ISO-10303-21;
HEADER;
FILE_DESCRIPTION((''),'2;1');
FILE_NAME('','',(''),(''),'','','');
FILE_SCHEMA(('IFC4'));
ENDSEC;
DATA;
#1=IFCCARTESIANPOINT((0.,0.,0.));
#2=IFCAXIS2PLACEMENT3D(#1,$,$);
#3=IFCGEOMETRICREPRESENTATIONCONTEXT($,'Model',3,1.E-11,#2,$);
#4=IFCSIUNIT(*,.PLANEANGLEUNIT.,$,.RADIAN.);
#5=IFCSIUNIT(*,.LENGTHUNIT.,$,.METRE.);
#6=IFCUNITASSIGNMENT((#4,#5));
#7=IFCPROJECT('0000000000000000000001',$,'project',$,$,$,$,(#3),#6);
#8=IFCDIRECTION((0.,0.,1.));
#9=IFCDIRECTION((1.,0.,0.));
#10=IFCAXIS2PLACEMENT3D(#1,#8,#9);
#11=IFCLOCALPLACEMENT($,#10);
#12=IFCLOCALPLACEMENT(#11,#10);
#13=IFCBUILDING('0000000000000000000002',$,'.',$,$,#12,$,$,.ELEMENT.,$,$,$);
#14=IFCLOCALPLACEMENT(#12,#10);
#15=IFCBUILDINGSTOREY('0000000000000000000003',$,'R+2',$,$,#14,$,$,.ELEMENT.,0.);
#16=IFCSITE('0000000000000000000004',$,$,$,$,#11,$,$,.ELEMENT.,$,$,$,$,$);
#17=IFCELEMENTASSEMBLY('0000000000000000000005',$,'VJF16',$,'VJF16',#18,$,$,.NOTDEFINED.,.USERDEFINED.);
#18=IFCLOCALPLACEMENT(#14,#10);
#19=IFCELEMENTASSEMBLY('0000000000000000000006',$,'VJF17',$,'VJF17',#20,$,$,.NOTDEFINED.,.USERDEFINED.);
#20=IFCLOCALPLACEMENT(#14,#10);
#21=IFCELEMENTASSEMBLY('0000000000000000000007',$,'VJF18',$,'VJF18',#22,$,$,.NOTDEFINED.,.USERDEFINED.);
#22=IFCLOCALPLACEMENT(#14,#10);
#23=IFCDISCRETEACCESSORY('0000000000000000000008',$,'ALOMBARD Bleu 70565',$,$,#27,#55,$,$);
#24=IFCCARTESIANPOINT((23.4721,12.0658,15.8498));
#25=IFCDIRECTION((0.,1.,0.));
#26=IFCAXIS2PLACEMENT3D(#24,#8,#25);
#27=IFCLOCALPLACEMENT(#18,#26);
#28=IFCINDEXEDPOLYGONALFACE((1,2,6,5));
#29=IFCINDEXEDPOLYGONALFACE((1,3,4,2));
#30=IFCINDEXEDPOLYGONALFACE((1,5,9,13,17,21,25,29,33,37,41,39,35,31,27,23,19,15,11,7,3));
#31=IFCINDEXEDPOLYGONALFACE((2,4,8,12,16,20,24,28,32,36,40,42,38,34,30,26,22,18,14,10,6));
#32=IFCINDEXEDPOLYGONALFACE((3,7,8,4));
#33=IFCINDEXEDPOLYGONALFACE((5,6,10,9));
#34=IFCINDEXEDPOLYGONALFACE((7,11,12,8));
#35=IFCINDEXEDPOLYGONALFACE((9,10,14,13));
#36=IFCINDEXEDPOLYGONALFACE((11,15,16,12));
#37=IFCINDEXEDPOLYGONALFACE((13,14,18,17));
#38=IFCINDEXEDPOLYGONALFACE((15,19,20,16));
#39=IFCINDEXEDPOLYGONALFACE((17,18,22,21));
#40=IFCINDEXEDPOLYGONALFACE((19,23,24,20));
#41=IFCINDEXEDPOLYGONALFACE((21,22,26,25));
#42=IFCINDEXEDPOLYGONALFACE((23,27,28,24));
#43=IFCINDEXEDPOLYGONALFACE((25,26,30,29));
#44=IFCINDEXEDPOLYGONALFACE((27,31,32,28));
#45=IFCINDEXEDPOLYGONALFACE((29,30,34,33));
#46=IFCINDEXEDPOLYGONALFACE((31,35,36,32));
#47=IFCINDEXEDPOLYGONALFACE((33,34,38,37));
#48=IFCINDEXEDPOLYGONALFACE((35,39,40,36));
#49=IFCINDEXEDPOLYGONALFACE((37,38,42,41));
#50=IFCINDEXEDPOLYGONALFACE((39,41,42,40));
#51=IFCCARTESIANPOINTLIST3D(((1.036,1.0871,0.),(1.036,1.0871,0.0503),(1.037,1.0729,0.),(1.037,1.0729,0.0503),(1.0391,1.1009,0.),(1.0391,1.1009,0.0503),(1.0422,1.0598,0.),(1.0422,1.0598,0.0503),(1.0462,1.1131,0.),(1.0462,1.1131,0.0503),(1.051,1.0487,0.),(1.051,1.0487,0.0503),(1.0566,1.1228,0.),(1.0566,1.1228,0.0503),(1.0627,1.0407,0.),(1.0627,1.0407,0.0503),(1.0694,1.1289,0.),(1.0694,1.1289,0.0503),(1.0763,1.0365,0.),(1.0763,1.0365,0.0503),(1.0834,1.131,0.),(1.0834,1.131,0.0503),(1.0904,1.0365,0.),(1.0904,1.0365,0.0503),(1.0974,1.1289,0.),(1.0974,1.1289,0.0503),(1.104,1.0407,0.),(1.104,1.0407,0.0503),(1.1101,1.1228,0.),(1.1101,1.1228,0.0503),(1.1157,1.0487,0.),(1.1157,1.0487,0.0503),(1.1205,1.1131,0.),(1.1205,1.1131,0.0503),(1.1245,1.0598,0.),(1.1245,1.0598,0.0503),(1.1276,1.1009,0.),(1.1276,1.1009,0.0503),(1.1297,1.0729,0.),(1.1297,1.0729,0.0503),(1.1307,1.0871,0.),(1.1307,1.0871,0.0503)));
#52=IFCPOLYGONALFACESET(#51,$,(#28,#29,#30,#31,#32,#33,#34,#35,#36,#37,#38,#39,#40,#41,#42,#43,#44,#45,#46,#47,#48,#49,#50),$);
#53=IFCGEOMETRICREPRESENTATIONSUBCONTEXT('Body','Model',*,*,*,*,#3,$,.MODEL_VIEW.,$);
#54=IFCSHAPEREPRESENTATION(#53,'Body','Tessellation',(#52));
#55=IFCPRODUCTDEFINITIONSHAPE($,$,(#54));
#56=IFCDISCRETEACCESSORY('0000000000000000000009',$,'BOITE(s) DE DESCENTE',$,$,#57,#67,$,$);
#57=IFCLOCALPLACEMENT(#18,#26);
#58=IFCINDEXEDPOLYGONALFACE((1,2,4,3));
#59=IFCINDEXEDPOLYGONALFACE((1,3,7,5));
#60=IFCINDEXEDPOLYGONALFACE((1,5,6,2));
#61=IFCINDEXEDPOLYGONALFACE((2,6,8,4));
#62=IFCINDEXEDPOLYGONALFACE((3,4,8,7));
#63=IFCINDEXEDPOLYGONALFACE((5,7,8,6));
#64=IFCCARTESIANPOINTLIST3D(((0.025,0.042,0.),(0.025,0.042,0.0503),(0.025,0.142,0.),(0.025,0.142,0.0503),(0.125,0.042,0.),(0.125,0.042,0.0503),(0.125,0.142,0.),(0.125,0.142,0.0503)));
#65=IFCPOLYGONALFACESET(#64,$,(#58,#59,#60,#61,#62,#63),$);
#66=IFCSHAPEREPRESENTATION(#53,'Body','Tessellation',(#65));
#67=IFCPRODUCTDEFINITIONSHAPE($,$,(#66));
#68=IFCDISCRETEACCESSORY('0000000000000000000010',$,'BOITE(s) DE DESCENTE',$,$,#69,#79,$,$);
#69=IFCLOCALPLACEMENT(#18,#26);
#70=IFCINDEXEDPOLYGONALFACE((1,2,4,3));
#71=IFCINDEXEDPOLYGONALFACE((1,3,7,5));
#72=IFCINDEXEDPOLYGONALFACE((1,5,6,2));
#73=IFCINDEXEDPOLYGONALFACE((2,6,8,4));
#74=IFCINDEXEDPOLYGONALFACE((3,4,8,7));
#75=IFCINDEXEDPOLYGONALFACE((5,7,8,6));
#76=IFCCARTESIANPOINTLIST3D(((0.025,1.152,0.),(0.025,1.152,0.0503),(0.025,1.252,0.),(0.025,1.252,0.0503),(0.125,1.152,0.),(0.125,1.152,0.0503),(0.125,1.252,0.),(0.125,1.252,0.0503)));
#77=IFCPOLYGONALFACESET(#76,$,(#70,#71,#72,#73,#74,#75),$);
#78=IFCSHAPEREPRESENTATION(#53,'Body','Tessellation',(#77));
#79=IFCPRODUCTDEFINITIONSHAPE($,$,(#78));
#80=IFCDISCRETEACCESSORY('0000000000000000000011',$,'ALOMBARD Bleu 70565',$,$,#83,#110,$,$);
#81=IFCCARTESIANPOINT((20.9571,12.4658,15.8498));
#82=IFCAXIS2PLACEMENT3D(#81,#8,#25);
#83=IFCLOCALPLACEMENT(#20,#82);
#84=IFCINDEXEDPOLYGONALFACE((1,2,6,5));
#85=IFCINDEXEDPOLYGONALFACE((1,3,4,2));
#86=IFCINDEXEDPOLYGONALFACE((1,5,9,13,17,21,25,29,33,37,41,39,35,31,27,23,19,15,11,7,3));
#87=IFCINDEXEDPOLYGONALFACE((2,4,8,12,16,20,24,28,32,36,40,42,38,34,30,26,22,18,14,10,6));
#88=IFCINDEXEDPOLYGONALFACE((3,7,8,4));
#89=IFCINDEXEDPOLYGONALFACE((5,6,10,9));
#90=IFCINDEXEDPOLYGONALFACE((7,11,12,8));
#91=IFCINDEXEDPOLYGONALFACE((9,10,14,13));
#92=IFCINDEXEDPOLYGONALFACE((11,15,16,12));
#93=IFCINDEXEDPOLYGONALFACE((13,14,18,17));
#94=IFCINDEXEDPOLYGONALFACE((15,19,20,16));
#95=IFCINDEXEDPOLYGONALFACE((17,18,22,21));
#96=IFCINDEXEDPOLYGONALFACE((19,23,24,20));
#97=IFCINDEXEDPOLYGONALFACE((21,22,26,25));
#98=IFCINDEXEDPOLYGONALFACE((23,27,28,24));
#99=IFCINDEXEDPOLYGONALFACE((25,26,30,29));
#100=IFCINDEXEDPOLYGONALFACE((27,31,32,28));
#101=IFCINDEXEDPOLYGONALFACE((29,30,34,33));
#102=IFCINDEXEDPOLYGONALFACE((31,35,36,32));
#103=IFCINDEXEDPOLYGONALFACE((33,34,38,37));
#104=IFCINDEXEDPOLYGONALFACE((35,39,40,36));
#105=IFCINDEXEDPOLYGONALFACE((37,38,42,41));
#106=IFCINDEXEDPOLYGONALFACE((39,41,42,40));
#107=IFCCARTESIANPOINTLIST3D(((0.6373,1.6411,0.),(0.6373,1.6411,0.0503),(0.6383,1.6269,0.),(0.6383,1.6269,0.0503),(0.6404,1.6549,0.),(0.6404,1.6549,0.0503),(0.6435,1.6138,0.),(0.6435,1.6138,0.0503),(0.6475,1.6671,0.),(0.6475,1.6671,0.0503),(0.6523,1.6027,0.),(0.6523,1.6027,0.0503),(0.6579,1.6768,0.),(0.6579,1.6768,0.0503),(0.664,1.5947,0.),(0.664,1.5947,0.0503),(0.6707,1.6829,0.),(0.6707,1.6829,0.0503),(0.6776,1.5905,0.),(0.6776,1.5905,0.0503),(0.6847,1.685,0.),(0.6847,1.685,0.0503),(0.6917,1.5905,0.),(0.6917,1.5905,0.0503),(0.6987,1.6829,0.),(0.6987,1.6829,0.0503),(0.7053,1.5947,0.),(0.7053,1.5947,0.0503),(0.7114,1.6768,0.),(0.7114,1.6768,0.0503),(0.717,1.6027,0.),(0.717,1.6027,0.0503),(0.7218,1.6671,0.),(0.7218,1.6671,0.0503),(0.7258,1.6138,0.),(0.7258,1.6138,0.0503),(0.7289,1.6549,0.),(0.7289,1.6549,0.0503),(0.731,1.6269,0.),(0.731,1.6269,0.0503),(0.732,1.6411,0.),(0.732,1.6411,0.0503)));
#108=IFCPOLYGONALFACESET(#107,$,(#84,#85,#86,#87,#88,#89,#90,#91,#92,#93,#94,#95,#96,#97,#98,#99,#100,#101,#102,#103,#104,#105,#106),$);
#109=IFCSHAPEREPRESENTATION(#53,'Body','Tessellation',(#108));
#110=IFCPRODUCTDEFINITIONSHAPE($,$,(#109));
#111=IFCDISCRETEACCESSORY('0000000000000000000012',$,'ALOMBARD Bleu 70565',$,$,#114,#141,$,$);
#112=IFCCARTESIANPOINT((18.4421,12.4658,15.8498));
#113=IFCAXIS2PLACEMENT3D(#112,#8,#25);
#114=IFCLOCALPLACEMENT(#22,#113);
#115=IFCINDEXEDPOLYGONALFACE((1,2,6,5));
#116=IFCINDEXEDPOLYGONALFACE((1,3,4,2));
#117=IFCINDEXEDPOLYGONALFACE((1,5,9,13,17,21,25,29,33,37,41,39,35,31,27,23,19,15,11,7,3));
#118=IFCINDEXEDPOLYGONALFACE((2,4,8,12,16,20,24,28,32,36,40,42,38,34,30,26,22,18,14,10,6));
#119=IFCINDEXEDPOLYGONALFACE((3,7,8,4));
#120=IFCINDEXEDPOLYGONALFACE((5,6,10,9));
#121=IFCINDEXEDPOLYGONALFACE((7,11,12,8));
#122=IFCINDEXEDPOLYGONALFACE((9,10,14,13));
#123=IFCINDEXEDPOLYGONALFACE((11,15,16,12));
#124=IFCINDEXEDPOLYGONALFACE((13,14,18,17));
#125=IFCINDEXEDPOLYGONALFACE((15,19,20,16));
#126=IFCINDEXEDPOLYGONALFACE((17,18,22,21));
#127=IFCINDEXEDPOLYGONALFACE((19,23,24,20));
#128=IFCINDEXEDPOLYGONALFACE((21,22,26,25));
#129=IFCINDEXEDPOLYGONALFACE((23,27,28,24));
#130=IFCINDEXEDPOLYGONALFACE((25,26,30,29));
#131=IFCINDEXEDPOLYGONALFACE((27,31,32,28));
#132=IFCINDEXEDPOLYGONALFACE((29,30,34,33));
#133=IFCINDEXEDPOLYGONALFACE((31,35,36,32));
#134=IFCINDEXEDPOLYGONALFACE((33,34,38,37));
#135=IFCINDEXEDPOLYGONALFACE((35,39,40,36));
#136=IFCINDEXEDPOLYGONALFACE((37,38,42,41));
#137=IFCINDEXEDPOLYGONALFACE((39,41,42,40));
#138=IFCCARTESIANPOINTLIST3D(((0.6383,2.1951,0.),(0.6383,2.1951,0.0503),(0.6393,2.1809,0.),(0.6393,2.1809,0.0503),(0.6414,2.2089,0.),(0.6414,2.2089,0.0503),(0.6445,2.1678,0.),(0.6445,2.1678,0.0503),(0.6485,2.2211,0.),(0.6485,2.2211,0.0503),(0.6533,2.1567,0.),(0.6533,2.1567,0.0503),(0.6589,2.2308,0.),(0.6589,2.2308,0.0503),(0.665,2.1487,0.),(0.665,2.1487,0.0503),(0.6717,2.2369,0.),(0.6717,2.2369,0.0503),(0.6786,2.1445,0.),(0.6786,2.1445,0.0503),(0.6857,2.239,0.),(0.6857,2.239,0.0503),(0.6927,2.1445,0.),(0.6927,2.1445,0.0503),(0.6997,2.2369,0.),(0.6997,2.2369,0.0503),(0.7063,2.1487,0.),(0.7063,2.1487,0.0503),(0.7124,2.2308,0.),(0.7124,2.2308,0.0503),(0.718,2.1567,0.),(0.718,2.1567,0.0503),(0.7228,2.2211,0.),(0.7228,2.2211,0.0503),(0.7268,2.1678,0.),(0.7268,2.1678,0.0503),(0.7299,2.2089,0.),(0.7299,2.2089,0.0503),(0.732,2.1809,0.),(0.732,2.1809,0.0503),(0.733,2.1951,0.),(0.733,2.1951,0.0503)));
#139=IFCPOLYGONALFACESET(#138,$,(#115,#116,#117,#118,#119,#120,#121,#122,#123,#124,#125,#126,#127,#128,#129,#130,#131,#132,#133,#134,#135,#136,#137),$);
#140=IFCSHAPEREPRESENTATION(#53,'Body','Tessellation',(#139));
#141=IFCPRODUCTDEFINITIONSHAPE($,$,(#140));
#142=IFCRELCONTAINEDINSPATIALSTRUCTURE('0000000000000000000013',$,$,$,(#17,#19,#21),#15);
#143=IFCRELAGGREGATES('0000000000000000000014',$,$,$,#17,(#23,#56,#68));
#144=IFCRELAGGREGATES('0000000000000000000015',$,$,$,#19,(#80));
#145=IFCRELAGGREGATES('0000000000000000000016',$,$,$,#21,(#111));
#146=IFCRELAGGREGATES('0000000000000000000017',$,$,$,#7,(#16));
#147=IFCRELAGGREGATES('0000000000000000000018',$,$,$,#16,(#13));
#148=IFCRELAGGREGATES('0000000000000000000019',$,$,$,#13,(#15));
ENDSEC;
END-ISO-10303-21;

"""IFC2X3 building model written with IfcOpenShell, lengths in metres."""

from ifc_helpers import new_model, si_unit, frame, frame_2d, origin, origin_with_axes, place, context, subcontext, project, spatial, polyline, circle, outline, extrude, element, aggregate, save


model = new_model("IFC2X3")

# Units and contexts
model_context = context("Model", 3, precision=1e-11, world=origin())
body_context = subcontext(model_context, "Body", "Model", "MODEL_VIEW")
ifc_project = project(units=[si_unit("PLANEANGLEUNIT", "RADIAN"), si_unit("LENGTHUNIT", "METRE")], contexts=[model_context])

# Site, building, storey
site_placement = place(None, origin_with_axes())
site = spatial("IfcSite", under=ifc_project, at=site_placement, CompositionType="ELEMENT")
building_placement = place(site_placement, origin_with_axes())
building = spatial("IfcBuilding", under=site, at=building_placement, Name=".", CompositionType="ELEMENT")
storey_placement = place(building_placement, origin_with_axes())
storey = spatial("IfcBuildingStorey", under=building, at=storey_placement, Name="R+2", CompositionType="ELEMENT", Elevation=0.0)

# Element assembly
assembly_1_placement = place(storey_placement, origin_with_axes())
assembly_1 = element("IfcElementAssembly", 1, at=assembly_1_placement, inside=storey, Name="VJF16", ObjectType="VJF16", AssemblyPlace="NOTDEFINED", PredefinedType="USERDEFINED")

# Element assemblies
assembly_2_placement = place(storey_placement, origin_with_axes())
assembly_2 = element("IfcElementAssembly", 2, at=assembly_2_placement, inside=storey, Name="VJF17", ObjectType="VJF17", AssemblyPlace="NOTDEFINED", PredefinedType="USERDEFINED")
assembly_3_placement = place(storey_placement, origin_with_axes())
assembly_3 = element("IfcElementAssembly", 3, at=assembly_3_placement, inside=storey, Name="VJF18", ObjectType="VJF18", AssemblyPlace="NOTDEFINED", PredefinedType="USERDEFINED")

# Discrete accessories
discrete_accessory_1_placement = place(assembly_1_placement, frame((23.4721, 12.0658, 15.8498), z_axis=(0.0, 0.0, 1.0), x_axis=(0.0, 1.0, 0.0)))
discrete_accessory_1 = element("IfcDiscreteAccessory", 4, at=discrete_accessory_1_placement, Name="ALOMBARD Bleu 70565", context=body_context, shape_type="SweptSolid", body=[
    extrude(circle(Radius=0.0475, at=frame_2d((1.0835, -1.0834), x_axis=(1.0, 0.0))), frame((0.0, 0.0, 0.0), z_axis=(0.0, 0.0, 1.0), x_axis=(0.0, 1.0, 0.0)), (0.0, 0.0, 1.0), 0.0503),
])
discrete_accessory_2_placement = place(assembly_1_placement, frame((23.4721, 12.0658, 15.8498), z_axis=(0.0, 0.0, 1.0), x_axis=(0.0, 1.0, 0.0)))
discrete_accessory_2 = element("IfcDiscreteAccessory", 5, at=discrete_accessory_2_placement, Name="BOITE(s) DE DESCENTE", context=body_context, shape_type="SweptSolid", body=[
    extrude(outline(polyline([(0.042, -0.025), (0.042, -0.125), (0.142, -0.125), (0.142, -0.025), (0.042, -0.025)])), frame((0.0, 0.0, 0.0), z_axis=(0.0, 0.0, 1.0), x_axis=(0.0, 1.0, 0.0)), (0.0, 0.0, 1.0), 0.0503),
])
discrete_accessory_3_placement = place(assembly_1_placement, frame((23.4721, 12.0658, 15.8498), z_axis=(0.0, 0.0, 1.0), x_axis=(0.0, 1.0, 0.0)))
discrete_accessory_3 = element("IfcDiscreteAccessory", 6, at=discrete_accessory_3_placement, Name="BOITE(s) DE DESCENTE", context=body_context, shape_type="SweptSolid", body=[
    extrude(outline(polyline([(1.152, -0.025), (1.152, -0.125), (1.252, -0.125), (1.252, -0.025), (1.152, -0.025)])), frame((0.0, 0.0, 0.0), z_axis=(0.0, 0.0, 1.0), x_axis=(0.0, 1.0, 0.0)), (0.0, 0.0, 1.0), 0.0503),
])

aggregate(assembly_1, [discrete_accessory_1, discrete_accessory_2, discrete_accessory_3])

# Discrete accessory
discrete_accessory_4_placement = place(assembly_2_placement, frame((20.9571, 12.4658, 15.8498), z_axis=(0.0, 0.0, 1.0), x_axis=(0.0, 1.0, 0.0)))
discrete_accessory_4 = element("IfcDiscreteAccessory", 7, at=discrete_accessory_4_placement, Name="ALOMBARD Bleu 70565", context=body_context, shape_type="SweptSolid", body=[
    extrude(circle(Radius=0.0475, at=frame_2d((1.6375, -0.6847), x_axis=(1.0, 0.0))), frame((0.0, 0.0, 0.0), z_axis=(0.0, 0.0, 1.0), x_axis=(0.0, 1.0, 0.0)), (0.0, 0.0, 1.0), 0.0503),
])

aggregate(assembly_2, [discrete_accessory_4])

# Discrete accessory
discrete_accessory_5_placement = place(assembly_3_placement, frame((18.4421, 12.4658, 15.8498), z_axis=(0.0, 0.0, 1.0), x_axis=(0.0, 1.0, 0.0)))
discrete_accessory_5 = element("IfcDiscreteAccessory", 8, at=discrete_accessory_5_placement, Name="ALOMBARD Bleu 70565", context=body_context, shape_type="SweptSolid", body=[
    extrude(circle(Radius=0.0475, at=frame_2d((2.1915, -0.6857), x_axis=(1.0, 0.0))), frame((0.0, 0.0, 0.0), z_axis=(0.0, 0.0, 1.0), x_axis=(0.0, 1.0, 0.0)), (0.0, 0.0, 1.0), 0.0503),
])

aggregate(assembly_3, [discrete_accessory_5])

save(model, "model.ifc")
